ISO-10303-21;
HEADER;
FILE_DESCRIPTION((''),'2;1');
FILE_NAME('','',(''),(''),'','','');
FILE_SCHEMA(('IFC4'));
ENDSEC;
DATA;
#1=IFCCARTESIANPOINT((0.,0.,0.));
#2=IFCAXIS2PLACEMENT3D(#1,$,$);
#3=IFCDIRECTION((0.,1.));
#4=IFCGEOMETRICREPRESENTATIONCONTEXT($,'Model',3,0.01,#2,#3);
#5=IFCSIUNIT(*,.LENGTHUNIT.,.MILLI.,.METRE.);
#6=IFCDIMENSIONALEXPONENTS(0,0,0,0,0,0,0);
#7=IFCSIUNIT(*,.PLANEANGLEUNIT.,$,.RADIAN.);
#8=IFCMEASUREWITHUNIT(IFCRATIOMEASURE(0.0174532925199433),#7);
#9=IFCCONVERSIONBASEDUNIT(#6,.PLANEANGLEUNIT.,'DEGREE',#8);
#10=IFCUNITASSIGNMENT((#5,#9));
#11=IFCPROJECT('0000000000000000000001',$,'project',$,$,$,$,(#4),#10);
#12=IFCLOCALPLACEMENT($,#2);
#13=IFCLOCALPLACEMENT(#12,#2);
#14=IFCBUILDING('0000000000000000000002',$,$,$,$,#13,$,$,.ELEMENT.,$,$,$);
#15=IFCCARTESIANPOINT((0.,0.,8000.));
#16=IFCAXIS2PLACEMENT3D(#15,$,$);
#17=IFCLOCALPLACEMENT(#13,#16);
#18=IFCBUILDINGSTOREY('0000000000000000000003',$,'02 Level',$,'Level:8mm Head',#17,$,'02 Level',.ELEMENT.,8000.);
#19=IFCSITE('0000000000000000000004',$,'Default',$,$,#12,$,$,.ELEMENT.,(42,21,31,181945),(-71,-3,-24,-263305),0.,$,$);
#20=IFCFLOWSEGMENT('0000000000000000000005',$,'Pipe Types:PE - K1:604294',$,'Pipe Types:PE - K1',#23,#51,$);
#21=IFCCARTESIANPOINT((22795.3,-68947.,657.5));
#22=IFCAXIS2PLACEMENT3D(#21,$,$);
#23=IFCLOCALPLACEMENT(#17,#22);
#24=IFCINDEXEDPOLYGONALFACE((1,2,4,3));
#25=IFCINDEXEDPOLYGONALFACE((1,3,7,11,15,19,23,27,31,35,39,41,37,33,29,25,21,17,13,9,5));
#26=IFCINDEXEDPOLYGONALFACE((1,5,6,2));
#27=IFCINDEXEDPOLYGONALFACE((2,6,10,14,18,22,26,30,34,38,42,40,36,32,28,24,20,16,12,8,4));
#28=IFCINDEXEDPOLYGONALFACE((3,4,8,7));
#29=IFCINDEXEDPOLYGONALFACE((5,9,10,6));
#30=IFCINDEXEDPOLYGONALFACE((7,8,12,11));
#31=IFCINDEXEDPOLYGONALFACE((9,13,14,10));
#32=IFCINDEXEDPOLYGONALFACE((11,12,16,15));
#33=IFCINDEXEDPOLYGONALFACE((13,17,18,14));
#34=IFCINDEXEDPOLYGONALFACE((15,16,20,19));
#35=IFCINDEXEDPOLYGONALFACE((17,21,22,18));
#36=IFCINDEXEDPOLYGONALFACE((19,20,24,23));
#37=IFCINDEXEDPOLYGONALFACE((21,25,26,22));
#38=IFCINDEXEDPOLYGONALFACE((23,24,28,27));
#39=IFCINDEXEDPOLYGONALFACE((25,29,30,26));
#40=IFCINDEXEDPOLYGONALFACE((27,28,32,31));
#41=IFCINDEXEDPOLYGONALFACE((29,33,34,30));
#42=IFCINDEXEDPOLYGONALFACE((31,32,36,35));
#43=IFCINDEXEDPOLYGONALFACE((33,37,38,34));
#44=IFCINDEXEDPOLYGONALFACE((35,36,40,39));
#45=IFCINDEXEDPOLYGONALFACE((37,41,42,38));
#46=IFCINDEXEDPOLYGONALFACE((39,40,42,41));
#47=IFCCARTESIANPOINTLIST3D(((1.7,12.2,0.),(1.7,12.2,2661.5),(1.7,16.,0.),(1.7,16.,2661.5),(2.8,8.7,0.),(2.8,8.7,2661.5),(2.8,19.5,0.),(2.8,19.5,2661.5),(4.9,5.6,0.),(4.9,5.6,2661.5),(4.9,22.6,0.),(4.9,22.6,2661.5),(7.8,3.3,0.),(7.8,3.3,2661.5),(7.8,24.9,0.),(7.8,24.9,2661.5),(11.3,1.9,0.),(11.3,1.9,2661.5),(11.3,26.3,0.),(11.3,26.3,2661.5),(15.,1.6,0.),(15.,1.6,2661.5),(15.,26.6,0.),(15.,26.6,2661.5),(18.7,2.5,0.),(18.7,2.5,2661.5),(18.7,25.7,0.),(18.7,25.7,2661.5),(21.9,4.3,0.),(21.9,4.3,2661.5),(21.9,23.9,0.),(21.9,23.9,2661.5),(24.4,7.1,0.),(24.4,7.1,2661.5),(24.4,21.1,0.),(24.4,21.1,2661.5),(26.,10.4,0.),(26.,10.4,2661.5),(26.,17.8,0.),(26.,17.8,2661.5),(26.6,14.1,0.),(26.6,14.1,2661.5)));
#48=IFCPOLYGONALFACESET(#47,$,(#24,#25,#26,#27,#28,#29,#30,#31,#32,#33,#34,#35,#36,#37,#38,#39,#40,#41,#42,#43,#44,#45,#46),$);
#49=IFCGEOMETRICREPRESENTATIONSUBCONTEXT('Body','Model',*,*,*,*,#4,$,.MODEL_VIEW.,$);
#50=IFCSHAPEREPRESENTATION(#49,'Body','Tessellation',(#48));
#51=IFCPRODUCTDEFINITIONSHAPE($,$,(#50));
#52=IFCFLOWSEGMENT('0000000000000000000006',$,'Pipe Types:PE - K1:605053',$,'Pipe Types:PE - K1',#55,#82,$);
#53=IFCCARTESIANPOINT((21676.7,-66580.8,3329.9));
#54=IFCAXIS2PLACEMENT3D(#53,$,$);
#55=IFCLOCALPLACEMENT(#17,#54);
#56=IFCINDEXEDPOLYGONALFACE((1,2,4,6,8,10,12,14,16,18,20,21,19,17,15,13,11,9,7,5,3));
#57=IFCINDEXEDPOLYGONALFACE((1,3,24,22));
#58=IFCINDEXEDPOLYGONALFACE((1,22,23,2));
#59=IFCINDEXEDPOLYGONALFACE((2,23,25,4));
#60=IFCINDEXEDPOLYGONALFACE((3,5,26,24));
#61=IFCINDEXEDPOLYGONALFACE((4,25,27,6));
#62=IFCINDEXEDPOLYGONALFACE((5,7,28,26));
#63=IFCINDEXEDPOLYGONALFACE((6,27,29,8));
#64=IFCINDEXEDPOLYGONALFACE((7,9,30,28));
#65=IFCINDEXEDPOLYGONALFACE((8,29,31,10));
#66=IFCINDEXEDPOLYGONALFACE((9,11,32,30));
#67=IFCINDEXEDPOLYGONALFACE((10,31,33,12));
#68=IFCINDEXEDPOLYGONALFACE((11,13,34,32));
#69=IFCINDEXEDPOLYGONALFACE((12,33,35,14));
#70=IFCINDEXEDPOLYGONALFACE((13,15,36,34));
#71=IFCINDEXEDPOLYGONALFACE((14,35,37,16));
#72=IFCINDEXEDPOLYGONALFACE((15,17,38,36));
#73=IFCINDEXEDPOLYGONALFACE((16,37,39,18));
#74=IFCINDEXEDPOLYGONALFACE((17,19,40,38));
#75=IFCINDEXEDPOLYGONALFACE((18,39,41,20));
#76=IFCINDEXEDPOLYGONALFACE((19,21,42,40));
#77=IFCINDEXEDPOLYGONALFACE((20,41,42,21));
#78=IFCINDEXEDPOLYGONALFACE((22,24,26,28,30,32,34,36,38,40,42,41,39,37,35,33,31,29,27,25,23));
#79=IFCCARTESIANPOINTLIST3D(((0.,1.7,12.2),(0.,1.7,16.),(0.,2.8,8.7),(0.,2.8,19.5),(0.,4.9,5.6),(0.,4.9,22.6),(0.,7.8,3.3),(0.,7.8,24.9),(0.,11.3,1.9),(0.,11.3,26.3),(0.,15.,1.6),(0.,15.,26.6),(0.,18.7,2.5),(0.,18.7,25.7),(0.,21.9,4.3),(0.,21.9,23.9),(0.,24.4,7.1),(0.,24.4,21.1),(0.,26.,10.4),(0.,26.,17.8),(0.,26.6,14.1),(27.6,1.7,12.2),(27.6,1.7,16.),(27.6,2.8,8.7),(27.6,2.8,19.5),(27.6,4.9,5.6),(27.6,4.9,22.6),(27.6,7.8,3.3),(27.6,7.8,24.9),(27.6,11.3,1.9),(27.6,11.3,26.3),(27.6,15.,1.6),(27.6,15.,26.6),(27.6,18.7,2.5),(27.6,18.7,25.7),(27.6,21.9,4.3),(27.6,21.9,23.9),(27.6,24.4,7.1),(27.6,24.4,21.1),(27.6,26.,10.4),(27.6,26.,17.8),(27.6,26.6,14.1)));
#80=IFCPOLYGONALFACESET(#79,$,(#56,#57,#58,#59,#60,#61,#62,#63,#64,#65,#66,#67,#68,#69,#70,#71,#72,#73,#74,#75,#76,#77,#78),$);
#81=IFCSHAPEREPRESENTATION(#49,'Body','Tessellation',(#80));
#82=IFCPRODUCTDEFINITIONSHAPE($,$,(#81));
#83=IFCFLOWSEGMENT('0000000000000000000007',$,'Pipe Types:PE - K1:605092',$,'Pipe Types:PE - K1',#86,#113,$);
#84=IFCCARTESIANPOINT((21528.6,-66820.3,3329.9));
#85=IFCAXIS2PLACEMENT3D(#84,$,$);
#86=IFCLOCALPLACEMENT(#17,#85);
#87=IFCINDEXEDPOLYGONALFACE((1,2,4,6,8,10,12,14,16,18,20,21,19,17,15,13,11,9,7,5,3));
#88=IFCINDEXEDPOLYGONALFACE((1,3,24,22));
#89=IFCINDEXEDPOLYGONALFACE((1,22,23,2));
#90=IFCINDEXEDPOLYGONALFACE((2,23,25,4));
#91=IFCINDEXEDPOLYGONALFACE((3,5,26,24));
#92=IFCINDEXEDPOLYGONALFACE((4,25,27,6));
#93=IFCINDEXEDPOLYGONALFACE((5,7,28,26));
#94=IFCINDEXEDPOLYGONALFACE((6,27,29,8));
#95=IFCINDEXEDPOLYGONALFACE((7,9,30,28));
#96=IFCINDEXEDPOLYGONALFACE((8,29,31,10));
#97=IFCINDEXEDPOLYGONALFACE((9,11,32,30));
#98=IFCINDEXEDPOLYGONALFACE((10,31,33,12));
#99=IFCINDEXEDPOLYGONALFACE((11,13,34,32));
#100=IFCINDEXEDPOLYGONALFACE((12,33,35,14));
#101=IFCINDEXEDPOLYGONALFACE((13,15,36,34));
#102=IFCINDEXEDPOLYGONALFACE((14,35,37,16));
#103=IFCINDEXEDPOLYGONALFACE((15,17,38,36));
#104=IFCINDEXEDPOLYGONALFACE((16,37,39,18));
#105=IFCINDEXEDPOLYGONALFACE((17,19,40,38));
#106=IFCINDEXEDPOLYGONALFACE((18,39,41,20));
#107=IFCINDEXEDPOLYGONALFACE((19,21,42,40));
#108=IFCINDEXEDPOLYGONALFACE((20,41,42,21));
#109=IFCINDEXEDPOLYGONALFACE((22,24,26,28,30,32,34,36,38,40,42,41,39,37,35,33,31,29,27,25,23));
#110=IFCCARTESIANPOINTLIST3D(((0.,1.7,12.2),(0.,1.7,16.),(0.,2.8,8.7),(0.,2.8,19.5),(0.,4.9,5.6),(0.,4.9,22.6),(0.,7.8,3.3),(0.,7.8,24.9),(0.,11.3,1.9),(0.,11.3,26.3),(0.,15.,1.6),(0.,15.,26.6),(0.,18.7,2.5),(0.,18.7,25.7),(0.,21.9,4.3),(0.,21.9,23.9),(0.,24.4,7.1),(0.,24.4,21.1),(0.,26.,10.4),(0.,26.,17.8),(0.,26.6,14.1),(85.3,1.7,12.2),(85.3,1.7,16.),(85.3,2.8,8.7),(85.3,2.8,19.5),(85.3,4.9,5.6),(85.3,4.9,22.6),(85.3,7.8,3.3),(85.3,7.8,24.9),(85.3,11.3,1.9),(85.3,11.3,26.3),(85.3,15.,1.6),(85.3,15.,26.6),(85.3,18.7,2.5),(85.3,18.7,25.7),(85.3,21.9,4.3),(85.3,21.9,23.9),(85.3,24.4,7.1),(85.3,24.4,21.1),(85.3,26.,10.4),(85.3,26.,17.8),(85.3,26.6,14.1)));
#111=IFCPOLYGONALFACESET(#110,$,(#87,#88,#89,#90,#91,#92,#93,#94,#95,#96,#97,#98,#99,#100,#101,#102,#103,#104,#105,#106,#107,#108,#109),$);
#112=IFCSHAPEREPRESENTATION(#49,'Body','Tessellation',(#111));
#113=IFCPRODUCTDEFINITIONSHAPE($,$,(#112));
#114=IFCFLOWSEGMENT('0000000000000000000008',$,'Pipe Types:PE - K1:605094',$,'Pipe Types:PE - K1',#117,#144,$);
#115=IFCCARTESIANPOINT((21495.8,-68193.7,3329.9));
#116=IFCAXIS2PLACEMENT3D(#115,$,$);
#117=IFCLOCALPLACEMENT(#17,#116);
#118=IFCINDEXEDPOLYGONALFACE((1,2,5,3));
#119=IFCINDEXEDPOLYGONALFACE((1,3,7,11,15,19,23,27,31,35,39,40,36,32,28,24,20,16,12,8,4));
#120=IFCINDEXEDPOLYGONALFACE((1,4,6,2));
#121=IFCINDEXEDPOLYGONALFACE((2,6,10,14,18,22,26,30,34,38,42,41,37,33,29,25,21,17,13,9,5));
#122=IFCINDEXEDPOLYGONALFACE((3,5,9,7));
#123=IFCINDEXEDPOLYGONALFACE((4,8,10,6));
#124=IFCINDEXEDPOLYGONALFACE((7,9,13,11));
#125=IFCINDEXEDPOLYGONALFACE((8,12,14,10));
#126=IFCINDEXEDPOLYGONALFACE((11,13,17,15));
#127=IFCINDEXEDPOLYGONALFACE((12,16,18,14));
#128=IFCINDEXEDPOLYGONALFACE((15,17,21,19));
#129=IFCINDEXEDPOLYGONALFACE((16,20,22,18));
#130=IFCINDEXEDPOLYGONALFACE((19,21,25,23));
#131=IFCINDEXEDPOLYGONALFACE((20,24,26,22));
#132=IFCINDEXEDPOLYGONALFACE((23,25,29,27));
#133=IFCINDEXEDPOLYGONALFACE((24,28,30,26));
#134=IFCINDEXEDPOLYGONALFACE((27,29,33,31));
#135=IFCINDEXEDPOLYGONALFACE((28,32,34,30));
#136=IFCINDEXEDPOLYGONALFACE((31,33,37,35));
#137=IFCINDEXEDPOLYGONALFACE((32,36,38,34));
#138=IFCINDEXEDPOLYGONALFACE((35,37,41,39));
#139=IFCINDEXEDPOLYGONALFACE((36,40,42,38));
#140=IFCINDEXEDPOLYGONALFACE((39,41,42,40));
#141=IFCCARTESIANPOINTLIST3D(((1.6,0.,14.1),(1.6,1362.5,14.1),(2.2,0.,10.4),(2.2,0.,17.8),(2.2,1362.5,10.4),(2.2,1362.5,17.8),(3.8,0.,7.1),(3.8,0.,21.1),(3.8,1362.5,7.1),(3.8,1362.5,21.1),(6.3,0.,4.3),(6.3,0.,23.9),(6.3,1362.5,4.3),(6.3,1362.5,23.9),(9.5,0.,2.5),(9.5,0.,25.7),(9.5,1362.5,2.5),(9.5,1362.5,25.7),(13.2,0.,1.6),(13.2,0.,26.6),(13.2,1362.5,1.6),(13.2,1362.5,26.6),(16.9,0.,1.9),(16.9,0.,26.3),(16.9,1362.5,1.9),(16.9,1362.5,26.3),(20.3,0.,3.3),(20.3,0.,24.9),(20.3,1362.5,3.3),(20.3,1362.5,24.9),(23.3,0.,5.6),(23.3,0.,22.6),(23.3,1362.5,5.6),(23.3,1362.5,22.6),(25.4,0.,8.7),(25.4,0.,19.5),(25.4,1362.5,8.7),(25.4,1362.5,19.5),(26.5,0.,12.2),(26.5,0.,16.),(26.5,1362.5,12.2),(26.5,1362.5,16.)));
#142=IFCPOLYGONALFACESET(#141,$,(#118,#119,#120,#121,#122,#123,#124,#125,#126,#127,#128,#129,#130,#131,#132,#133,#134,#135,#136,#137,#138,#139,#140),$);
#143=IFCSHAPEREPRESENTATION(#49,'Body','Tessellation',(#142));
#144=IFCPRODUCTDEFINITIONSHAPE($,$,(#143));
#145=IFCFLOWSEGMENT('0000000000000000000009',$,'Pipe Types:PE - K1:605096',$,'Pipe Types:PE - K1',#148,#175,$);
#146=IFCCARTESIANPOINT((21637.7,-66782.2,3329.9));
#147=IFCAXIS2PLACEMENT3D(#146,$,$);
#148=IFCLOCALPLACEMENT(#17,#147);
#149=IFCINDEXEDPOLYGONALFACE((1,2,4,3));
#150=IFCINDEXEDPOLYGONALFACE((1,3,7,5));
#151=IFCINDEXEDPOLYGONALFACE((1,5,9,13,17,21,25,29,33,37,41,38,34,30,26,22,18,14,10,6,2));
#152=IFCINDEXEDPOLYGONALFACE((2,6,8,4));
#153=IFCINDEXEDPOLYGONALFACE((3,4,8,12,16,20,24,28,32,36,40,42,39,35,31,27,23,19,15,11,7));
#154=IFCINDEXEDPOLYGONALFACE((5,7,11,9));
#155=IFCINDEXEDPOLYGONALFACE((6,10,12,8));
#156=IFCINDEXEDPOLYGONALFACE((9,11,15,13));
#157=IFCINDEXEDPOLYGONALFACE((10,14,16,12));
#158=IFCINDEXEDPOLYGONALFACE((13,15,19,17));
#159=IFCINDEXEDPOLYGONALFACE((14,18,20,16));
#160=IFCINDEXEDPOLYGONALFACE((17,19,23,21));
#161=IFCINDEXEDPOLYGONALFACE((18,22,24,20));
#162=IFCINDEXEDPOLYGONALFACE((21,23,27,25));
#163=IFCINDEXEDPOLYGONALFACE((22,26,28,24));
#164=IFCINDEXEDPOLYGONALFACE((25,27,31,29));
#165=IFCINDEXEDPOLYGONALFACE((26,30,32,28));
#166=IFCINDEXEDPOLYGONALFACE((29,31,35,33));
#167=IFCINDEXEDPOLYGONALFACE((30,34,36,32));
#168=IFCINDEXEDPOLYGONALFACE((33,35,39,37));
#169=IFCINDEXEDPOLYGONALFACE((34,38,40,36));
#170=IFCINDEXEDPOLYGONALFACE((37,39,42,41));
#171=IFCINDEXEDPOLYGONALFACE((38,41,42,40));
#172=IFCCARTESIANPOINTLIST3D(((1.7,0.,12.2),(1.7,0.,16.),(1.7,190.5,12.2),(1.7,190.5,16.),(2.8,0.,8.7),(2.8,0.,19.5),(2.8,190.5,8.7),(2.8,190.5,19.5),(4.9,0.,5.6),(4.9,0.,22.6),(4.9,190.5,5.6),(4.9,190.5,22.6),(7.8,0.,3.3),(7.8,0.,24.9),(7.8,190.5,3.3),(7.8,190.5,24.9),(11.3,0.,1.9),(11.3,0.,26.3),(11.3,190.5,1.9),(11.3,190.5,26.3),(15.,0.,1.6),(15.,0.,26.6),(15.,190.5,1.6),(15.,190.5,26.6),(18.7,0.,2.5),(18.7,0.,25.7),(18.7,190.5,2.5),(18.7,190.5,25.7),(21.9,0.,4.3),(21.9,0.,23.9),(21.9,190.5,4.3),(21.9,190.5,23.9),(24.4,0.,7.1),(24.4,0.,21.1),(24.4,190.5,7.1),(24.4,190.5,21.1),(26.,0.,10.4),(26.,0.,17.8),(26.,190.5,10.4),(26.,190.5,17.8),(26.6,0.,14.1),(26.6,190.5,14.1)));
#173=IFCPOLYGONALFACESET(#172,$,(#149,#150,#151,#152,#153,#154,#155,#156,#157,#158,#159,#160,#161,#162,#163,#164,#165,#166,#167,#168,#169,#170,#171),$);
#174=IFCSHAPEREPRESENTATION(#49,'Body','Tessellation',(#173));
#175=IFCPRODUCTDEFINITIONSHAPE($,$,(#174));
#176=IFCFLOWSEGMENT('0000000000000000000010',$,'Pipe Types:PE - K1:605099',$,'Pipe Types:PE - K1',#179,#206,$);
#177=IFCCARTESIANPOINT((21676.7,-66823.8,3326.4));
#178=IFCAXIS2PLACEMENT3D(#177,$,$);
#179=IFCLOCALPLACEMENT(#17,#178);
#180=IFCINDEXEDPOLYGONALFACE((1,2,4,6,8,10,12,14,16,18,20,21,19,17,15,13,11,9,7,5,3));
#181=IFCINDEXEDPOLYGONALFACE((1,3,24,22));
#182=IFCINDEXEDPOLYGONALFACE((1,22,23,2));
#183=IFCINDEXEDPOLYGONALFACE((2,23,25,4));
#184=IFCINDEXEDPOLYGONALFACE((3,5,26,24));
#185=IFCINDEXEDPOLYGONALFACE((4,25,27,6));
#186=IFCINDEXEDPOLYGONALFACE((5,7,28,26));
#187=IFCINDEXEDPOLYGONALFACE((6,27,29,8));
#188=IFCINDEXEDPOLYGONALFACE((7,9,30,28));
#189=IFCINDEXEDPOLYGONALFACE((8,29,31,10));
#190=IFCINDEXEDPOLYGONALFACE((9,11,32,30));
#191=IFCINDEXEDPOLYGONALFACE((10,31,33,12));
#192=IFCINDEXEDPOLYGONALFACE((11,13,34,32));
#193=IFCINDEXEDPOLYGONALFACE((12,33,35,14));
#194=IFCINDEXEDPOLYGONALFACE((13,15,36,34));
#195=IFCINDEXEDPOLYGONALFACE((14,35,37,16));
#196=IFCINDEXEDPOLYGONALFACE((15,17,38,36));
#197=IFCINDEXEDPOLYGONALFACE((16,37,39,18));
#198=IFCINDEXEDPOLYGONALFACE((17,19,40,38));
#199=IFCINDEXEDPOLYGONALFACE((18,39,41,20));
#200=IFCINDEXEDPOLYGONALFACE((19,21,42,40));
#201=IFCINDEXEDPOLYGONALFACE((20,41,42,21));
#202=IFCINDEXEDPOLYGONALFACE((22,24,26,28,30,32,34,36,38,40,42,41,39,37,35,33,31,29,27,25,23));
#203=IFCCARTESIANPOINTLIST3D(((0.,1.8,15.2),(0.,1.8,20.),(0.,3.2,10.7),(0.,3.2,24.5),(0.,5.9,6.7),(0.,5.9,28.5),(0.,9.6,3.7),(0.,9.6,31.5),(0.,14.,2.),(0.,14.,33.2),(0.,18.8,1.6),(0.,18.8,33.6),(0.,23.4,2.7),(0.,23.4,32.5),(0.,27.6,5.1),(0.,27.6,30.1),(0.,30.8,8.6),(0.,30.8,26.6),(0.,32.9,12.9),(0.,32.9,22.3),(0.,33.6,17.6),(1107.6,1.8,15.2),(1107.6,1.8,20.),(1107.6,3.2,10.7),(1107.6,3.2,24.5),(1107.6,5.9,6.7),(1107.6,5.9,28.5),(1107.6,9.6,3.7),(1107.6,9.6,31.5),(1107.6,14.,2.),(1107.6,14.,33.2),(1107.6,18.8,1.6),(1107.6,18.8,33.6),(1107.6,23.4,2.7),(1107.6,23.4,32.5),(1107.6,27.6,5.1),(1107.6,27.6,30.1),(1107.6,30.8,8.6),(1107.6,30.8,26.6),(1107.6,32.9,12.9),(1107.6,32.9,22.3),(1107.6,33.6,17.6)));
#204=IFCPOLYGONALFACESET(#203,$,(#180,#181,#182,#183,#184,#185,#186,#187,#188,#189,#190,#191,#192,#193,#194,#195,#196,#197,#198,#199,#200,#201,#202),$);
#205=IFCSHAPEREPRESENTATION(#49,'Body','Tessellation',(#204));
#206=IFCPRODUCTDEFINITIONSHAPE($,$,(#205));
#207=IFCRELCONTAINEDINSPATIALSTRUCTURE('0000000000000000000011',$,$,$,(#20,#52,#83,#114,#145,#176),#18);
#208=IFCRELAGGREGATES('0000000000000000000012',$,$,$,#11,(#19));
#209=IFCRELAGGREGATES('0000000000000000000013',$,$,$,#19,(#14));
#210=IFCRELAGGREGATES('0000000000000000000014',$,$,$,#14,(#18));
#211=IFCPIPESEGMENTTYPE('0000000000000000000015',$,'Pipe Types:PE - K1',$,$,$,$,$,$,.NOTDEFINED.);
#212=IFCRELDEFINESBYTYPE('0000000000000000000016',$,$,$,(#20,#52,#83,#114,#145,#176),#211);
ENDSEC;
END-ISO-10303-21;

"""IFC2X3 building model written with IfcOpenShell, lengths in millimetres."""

from ifc_helpers import new_model, entity, si_unit, converted_unit, direction, frame, frame_2d, origin, origin_2d_with_axis, place, context, subcontext, project, spatial, circle, extrude, type_object, element, save


model = new_model("IFC2X3")

# Units and contexts
model_context = context("Model", 3, precision=0.01, world=origin(), true_north=direction((0.0, 1.0)))
body_context = subcontext(model_context, "Body", "Model", "MODEL_VIEW")
ifc_project = project(units=[si_unit("LENGTHUNIT", "METRE", prefix="MILLI"), converted_unit("PLANEANGLEUNIT", "DEGREE", entity("IfcRatioMeasure", 0.0174532925199433), si_unit("PLANEANGLEUNIT", "RADIAN"), dimensions=[0, 0, 0, 0, 0, 0, 0])], contexts=[model_context])

# Site, building, storey
site_placement = place(None, origin())
site = spatial("IfcSite", under=ifc_project, at=site_placement, Name="Default", CompositionType="ELEMENT", RefLatitude=(42, 21, 31, 181945), RefLongitude=(-71, -3, -24, -263305), RefElevation=0.0)
building_placement = place(site_placement, origin())
building = spatial("IfcBuilding", under=site, at=building_placement, CompositionType="ELEMENT")
storey_placement = place(building_placement, frame((0.0, 0.0, 8000.0)))
storey = spatial("IfcBuildingStorey", under=building, at=storey_placement, Name="02 Level", ObjectType="Level:8mm Head", LongName="02 Level", CompositionType="ELEMENT", Elevation=8000.0)

# Flow segments
pipe_segment_type = type_object("IfcPipeSegmentType", Name="Pipe Types:PE - K1", PredefinedType="NOTDEFINED")
flow_segment_1_placement = place(storey_placement, frame((22795.3, -68947.0, 657.5)))
element("IfcFlowSegment", 1, at=flow_segment_1_placement, inside=storey, type_object=pipe_segment_type, Name="Pipe Types:PE - K1:604294", ObjectType="Pipe Types:PE - K1", context=body_context, shape_type="SweptSolid", body=[
    extrude(circle(Radius=12.5, at=frame_2d((0.0, 0.0), x_axis=(1.0, 0.0))), frame((14.1, 14.1, 0.0)), (0.0, 0.0, 1.0), 2661.5),
])
flow_segment_2_placement = place(storey_placement, frame((21676.7, -66580.8, 3329.9)))
element("IfcFlowSegment", 2, at=flow_segment_2_placement, inside=storey, type_object=pipe_segment_type, Name="Pipe Types:PE - K1:605053", ObjectType="Pipe Types:PE - K1", context=body_context, shape_type="SweptSolid", body=[
    extrude(circle(Radius=12.5, at=frame_2d((0.0, 0.0), x_axis=(1.0, 0.0))), frame((0.0, 14.1, 14.1), z_axis=(1.0, 0.0, 0.0), x_axis=(0.0, 1.0, 0.0)), (0.0, 0.0, 1.0), 27.6),
])
flow_segment_3_placement = place(storey_placement, frame((21528.6, -66820.3, 3329.9)))
element("IfcFlowSegment", 3, at=flow_segment_3_placement, inside=storey, type_object=pipe_segment_type, Name="Pipe Types:PE - K1:605092", ObjectType="Pipe Types:PE - K1", context=body_context, shape_type="SweptSolid", body=[
    extrude(circle(Radius=12.5, at=origin_2d_with_axis()), frame((0.0, 14.1, 14.1), z_axis=(1.0, 0.0, 0.0), x_axis=(0.0, 1.0, 0.0)), (0.0, 0.0, 1.0), 85.3),
])
flow_segment_4_placement = place(storey_placement, frame((21495.8, -68193.7, 3329.9)))
element("IfcFlowSegment", 4, at=flow_segment_4_placement, inside=storey, type_object=pipe_segment_type, Name="Pipe Types:PE - K1:605094", ObjectType="Pipe Types:PE - K1", context=body_context, shape_type="SweptSolid", body=[
    extrude(circle(Radius=12.5, at=frame_2d((0.0, 0.0), x_axis=(1.0, 0.0))), frame((14.1, 0.0, 14.1), z_axis=(0.0, 1.0, 0.0), x_axis=(-1.0, 0.0, 0.0)), (0.0, 0.0, 1.0), 1362.5),
])
flow_segment_5_placement = place(storey_placement, frame((21637.7, -66782.2, 3329.9)))
element("IfcFlowSegment", 5, at=flow_segment_5_placement, inside=storey, type_object=pipe_segment_type, Name="Pipe Types:PE - K1:605096", ObjectType="Pipe Types:PE - K1", context=body_context, shape_type="SweptSolid", body=[
    extrude(circle(Radius=12.5, at=origin_2d_with_axis()), frame((14.1, 0.0, 14.1), z_axis=(0.0, 1.0, 0.0), x_axis=(1.0, 0.0, 0.0)), (0.0, 0.0, 1.0), 190.5),
])
flow_segment_6_placement = place(storey_placement, frame((21676.7, -66823.8, 3326.4)))
element("IfcFlowSegment", 6, at=flow_segment_6_placement, inside=storey, type_object=pipe_segment_type, Name="Pipe Types:PE - K1:605099", ObjectType="Pipe Types:PE - K1", context=body_context, shape_type="SweptSolid", body=[
    extrude(circle(Radius=16.0, at=frame_2d((0.0, 0.0), x_axis=(1.0, 0.0))), frame((0.0, 17.6, 17.6), z_axis=(1.0, 0.0, 0.0), x_axis=(0.0, 1.0, 0.0)), (0.0, 0.0, 1.0), 1107.6),
])

save(model, "model.ifc")
